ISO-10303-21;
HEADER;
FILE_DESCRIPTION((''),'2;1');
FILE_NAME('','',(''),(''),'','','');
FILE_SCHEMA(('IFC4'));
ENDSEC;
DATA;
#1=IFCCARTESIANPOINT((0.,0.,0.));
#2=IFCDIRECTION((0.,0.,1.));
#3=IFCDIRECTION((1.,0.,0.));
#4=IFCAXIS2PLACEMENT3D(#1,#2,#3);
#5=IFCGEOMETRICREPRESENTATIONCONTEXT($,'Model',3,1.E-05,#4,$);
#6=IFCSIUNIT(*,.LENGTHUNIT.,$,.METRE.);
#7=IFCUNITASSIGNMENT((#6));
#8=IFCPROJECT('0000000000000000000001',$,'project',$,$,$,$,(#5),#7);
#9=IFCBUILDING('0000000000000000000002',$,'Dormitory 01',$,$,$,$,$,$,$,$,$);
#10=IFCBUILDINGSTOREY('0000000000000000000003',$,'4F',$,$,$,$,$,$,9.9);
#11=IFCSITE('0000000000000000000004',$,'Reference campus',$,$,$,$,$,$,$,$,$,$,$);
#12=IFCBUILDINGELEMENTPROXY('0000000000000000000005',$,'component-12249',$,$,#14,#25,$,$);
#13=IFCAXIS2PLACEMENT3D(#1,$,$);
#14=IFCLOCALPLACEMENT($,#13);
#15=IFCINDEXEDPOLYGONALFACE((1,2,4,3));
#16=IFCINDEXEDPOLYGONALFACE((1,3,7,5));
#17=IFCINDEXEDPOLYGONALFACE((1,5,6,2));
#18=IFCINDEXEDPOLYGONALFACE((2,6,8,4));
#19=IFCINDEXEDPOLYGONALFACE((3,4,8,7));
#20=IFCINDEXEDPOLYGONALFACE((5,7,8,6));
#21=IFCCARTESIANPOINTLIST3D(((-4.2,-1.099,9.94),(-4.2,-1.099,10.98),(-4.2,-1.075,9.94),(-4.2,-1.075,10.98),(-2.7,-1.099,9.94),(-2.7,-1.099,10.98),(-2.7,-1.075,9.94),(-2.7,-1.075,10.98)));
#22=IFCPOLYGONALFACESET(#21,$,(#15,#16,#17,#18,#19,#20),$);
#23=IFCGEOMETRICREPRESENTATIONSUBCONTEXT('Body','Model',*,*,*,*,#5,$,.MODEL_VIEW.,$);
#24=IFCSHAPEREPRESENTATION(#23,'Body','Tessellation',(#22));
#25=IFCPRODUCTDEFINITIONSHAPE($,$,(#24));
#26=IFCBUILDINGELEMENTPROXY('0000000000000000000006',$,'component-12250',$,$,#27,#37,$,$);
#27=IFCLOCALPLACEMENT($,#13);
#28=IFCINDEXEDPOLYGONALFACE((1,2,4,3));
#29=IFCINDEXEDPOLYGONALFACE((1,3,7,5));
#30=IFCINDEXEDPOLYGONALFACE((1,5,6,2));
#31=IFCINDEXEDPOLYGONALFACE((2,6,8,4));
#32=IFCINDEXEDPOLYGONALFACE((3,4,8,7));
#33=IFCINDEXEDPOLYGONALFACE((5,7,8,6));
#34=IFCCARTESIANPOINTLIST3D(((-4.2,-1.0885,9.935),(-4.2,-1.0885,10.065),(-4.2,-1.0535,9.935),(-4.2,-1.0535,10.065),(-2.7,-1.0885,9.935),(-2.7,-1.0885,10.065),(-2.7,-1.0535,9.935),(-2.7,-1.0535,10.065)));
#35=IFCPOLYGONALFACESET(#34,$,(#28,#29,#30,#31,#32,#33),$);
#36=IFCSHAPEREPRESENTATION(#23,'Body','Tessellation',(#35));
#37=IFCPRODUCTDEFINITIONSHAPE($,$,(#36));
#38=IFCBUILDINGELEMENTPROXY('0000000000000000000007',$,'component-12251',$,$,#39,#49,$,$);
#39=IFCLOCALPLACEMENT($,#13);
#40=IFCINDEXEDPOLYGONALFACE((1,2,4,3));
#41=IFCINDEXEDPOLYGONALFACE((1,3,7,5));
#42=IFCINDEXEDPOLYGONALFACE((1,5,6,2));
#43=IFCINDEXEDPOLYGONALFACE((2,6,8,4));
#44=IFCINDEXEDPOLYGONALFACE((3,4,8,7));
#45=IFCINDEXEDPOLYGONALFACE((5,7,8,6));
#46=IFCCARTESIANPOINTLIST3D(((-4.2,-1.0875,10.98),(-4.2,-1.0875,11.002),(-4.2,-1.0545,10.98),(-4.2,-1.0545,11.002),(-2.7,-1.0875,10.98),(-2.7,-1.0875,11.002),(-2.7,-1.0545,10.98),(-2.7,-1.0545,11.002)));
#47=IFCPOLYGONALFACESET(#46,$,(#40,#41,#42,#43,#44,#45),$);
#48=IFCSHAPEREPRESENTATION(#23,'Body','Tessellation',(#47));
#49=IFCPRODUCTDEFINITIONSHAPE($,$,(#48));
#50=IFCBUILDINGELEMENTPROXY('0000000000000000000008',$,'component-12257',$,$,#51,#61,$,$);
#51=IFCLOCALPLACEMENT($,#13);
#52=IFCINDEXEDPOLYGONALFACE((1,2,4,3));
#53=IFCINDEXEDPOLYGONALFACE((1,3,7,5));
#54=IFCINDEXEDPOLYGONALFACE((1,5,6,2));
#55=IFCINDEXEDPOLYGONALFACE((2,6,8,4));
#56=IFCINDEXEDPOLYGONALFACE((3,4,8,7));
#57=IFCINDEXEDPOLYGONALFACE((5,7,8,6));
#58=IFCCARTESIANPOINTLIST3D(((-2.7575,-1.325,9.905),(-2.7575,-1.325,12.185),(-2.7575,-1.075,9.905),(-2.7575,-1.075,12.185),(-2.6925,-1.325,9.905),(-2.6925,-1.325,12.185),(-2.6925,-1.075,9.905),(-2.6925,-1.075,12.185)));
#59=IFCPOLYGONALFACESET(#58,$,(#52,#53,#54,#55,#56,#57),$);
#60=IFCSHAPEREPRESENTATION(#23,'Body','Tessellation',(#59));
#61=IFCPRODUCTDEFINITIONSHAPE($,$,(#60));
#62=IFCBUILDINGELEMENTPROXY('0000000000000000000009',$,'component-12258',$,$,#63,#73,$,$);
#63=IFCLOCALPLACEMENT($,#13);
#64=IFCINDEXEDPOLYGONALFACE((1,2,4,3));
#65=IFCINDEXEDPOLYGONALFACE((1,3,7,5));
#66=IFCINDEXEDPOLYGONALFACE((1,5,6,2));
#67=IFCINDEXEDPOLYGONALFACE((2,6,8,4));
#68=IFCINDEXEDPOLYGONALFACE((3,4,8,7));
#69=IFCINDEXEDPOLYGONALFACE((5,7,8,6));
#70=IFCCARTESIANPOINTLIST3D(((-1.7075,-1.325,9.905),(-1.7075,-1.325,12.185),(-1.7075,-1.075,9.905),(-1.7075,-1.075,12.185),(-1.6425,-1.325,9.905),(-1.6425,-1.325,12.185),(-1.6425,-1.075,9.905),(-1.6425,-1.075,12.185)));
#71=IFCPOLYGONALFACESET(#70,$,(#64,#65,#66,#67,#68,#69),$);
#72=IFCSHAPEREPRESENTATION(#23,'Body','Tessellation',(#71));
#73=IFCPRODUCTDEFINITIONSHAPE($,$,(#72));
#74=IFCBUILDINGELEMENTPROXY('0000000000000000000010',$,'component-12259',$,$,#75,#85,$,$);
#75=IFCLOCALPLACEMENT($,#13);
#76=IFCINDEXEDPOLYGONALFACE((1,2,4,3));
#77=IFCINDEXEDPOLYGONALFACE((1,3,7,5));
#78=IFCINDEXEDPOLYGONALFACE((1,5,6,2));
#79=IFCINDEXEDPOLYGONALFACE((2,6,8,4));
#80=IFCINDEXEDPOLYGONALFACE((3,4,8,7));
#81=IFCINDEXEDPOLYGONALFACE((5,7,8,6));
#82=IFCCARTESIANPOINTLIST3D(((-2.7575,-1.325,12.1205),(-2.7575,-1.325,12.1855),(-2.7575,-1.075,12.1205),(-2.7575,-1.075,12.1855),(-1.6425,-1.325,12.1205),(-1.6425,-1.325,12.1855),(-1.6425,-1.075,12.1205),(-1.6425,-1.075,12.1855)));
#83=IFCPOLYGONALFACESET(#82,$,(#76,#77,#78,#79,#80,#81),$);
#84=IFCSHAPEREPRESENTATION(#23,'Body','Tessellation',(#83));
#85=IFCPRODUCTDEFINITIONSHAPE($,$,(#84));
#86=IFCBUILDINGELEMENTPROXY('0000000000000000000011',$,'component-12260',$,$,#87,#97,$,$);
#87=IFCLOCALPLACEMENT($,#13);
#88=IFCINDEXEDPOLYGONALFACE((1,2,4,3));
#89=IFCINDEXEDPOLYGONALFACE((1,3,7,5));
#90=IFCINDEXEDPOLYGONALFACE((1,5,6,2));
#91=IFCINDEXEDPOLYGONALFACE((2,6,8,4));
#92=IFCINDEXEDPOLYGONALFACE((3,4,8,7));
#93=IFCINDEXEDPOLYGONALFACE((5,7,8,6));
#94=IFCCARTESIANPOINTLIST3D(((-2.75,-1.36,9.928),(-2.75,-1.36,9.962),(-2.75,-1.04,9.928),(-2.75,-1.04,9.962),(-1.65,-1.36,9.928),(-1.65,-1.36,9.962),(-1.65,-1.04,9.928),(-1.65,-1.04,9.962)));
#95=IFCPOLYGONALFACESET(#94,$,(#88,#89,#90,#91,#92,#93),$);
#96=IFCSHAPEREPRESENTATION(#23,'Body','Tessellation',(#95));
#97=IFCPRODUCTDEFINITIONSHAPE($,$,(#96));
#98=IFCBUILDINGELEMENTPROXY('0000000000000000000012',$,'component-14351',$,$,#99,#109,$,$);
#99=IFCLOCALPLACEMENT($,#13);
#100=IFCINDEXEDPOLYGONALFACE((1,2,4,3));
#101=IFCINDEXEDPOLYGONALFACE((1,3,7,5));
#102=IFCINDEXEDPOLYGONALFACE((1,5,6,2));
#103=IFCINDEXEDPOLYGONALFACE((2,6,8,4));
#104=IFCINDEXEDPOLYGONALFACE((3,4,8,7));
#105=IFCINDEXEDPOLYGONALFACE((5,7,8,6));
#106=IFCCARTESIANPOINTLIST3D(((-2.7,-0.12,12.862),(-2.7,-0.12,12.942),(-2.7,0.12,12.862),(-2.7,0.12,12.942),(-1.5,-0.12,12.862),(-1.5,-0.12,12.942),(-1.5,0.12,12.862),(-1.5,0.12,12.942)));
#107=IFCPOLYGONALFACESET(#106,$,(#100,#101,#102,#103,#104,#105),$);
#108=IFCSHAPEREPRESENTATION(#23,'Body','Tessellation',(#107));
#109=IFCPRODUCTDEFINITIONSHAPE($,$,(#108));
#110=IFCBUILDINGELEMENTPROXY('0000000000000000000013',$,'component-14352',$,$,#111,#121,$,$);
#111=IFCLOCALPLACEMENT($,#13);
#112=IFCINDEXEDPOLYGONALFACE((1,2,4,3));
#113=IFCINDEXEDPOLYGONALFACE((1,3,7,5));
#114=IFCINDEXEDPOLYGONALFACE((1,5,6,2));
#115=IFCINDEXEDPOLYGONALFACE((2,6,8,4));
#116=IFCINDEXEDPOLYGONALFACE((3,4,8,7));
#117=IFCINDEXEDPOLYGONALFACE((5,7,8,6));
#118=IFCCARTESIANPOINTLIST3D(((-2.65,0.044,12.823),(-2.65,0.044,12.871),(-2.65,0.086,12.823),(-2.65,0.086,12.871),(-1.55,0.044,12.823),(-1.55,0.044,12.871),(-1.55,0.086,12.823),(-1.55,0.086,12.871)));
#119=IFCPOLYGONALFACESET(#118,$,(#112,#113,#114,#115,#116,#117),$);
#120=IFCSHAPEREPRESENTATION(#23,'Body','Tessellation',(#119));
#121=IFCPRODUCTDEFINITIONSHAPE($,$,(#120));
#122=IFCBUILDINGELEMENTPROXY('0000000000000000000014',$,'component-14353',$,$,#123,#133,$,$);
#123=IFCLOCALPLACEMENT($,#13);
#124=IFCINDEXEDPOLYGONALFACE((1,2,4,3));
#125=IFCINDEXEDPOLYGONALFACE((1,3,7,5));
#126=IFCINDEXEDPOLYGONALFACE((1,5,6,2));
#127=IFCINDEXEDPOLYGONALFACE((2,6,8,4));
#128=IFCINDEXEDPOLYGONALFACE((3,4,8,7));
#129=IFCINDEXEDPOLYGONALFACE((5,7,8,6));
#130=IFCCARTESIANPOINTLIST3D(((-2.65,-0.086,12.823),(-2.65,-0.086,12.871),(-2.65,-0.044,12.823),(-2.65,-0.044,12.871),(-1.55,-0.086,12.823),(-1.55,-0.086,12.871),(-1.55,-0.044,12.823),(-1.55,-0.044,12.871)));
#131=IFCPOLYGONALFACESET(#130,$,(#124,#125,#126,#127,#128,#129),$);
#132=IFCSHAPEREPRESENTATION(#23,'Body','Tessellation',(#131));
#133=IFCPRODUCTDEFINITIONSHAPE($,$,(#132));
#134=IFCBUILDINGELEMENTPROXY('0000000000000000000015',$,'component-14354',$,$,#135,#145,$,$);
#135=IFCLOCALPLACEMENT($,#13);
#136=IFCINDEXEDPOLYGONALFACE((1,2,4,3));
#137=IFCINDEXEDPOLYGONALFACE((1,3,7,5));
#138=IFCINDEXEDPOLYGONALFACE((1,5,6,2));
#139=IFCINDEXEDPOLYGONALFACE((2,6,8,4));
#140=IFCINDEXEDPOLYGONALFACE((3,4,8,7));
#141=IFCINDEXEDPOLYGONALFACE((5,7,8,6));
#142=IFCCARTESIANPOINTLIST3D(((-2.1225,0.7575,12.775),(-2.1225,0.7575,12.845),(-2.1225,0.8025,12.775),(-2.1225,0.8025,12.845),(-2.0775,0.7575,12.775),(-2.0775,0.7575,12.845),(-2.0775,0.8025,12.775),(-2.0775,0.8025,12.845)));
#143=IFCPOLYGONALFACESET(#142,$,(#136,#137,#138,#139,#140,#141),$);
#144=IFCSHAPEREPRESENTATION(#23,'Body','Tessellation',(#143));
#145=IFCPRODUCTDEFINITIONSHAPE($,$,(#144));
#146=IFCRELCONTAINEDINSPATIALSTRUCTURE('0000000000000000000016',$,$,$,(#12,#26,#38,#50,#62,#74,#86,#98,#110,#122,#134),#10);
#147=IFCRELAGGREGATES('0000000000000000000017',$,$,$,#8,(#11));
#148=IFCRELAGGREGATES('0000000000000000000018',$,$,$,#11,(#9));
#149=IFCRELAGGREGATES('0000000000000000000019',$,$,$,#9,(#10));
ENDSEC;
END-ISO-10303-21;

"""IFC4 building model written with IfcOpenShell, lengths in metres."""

from ifc_helpers import new_model, si_unit, frame, origin, origin_with_axes, origin_2d, place, context, subcontext, project, spatial, rectangle, extrude, element, save


model = new_model("IFC4")

# Units and contexts
model_context = context("Model", 3, precision=1e-05, world=origin_with_axes())
body_context = subcontext(model_context, "Body", "Model", "MODEL_VIEW")
ifc_project = project(units=[si_unit("LENGTHUNIT", "METRE")], contexts=[model_context])

# Site, building, storey
site = spatial("IfcSite", under=ifc_project, Name="Reference campus")
building = spatial("IfcBuilding", under=site, Name="Dormitory 01")
storey = spatial("IfcBuildingStorey", under=building, Name="4F", Elevation=9.9)

# Building element proxies
proxy_1_placement = place(None, frame((-3.45, -1.087, 9.94), z_axis=(0.0, 0.0, 1.0), x_axis=(1.0, 0.0, 0.0)))
element("IfcBuildingElementProxy", 1, at=proxy_1_placement, inside=storey, Name="component-12249", context=body_context, shape_type="SweptSolid", body=[
    extrude(rectangle(XDim=1.5, YDim=0.024, at=origin_2d()), origin(), (0.0, 0.0, 1.0), 1.04),
])
proxy_2_placement = place(None, frame((-3.45, -1.071, 9.935), z_axis=(0.0, 0.0, 1.0), x_axis=(1.0, 0.0, 0.0)))
element("IfcBuildingElementProxy", 2, at=proxy_2_placement, inside=storey, Name="component-12250", context=body_context, shape_type="SweptSolid", body=[
    extrude(rectangle(XDim=1.5, YDim=0.035, at=origin_2d()), origin(), (0.0, 0.0, 1.0), 0.13),
])
proxy_3_placement = place(None, frame((-3.45, -1.071, 10.98), z_axis=(0.0, 0.0, 1.0), x_axis=(1.0, 0.0, 0.0)))
element("IfcBuildingElementProxy", 3, at=proxy_3_placement, inside=storey, Name="component-12251", context=body_context, shape_type="SweptSolid", body=[
    extrude(rectangle(XDim=1.5, YDim=0.033, at=origin_2d()), origin(), (0.0, 0.0, 1.0), 0.022),
])
for number, where, z_axis, x_axis, name in (
    (4, (-2.725, -1.2, 9.905), (0.0, 0.0, 1.0), (1.0, 0.0, 0.0), "component-12257"),
    (5, (-1.675, -1.2, 9.905), (0.0, 0.0, 1.0), (1.0, 0.0, 0.0), "component-12258"),
):
    element("IfcBuildingElementProxy", number, at=place(None, frame(where, z_axis=z_axis, x_axis=x_axis)), inside=storey, Name=name, context=body_context, shape_type="SweptSolid", body=[
        extrude(rectangle(XDim=0.065, YDim=0.25, at=origin_2d()), origin(), (0.0, 0.0, 1.0), 2.28),
    ])
proxy_4_placement = place(None, frame((-2.2, -1.2, 12.1205), z_axis=(0.0, 0.0, 1.0), x_axis=(1.0, 0.0, 0.0)))
element("IfcBuildingElementProxy", 6, at=proxy_4_placement, inside=storey, Name="component-12259", context=body_context, shape_type="SweptSolid", body=[
    extrude(rectangle(XDim=1.115, YDim=0.25, at=origin_2d()), origin(), (0.0, 0.0, 1.0), 0.065),
])
proxy_5_placement = place(None, frame((-2.2, -1.2, 9.928), z_axis=(0.0, 0.0, 1.0), x_axis=(1.0, 0.0, 0.0)))
element("IfcBuildingElementProxy", 7, at=proxy_5_placement, inside=storey, Name="component-12260", context=body_context, shape_type="SweptSolid", body=[
    extrude(rectangle(XDim=1.1, YDim=0.32, at=origin_2d()), origin(), (0.0, 0.0, 1.0), 0.034),
])
proxy_6_placement = place(None, frame((-2.1, 0.0, 12.862), z_axis=(0.0, 0.0, 1.0), x_axis=(1.0, 0.0, 0.0)))
element("IfcBuildingElementProxy", 8, at=proxy_6_placement, inside=storey, Name="component-14351", context=body_context, shape_type="SweptSolid", body=[
    extrude(rectangle(XDim=1.2, YDim=0.24, at=origin_2d()), origin(), (0.0, 0.0, 1.0), 0.08),
])
for number, where, z_axis, x_axis, name in (
    (9, (-2.1, 0.065, 12.823), (0.0, 0.0, 1.0), (1.0, 0.0, 0.0), "component-14352"),
    (10, (-2.1, -0.065, 12.823), (0.0, 0.0, 1.0), (1.0, 0.0, 0.0), "component-14353"),
):
    element("IfcBuildingElementProxy", number, at=place(None, frame(where, z_axis=z_axis, x_axis=x_axis)), inside=storey, Name=name, context=body_context, shape_type="SweptSolid", body=[
        extrude(rectangle(XDim=1.1, YDim=0.042, at=origin_2d()), origin(), (0.0, 0.0, 1.0), 0.048),
    ])
proxy_7_placement = place(None, frame((-2.1, 0.78, 12.775), z_axis=(0.0, 0.0, 1.0), x_axis=(1.0, 0.0, 0.0)))
element("IfcBuildingElementProxy", 11, at=proxy_7_placement, inside=storey, Name="component-14354", context=body_context, shape_type="SweptSolid", body=[
    extrude(rectangle(XDim=0.045, YDim=0.045, at=origin_2d()), origin(), (0.0, 0.0, 1.0), 0.07),
])

save(model, "model.ifc")
